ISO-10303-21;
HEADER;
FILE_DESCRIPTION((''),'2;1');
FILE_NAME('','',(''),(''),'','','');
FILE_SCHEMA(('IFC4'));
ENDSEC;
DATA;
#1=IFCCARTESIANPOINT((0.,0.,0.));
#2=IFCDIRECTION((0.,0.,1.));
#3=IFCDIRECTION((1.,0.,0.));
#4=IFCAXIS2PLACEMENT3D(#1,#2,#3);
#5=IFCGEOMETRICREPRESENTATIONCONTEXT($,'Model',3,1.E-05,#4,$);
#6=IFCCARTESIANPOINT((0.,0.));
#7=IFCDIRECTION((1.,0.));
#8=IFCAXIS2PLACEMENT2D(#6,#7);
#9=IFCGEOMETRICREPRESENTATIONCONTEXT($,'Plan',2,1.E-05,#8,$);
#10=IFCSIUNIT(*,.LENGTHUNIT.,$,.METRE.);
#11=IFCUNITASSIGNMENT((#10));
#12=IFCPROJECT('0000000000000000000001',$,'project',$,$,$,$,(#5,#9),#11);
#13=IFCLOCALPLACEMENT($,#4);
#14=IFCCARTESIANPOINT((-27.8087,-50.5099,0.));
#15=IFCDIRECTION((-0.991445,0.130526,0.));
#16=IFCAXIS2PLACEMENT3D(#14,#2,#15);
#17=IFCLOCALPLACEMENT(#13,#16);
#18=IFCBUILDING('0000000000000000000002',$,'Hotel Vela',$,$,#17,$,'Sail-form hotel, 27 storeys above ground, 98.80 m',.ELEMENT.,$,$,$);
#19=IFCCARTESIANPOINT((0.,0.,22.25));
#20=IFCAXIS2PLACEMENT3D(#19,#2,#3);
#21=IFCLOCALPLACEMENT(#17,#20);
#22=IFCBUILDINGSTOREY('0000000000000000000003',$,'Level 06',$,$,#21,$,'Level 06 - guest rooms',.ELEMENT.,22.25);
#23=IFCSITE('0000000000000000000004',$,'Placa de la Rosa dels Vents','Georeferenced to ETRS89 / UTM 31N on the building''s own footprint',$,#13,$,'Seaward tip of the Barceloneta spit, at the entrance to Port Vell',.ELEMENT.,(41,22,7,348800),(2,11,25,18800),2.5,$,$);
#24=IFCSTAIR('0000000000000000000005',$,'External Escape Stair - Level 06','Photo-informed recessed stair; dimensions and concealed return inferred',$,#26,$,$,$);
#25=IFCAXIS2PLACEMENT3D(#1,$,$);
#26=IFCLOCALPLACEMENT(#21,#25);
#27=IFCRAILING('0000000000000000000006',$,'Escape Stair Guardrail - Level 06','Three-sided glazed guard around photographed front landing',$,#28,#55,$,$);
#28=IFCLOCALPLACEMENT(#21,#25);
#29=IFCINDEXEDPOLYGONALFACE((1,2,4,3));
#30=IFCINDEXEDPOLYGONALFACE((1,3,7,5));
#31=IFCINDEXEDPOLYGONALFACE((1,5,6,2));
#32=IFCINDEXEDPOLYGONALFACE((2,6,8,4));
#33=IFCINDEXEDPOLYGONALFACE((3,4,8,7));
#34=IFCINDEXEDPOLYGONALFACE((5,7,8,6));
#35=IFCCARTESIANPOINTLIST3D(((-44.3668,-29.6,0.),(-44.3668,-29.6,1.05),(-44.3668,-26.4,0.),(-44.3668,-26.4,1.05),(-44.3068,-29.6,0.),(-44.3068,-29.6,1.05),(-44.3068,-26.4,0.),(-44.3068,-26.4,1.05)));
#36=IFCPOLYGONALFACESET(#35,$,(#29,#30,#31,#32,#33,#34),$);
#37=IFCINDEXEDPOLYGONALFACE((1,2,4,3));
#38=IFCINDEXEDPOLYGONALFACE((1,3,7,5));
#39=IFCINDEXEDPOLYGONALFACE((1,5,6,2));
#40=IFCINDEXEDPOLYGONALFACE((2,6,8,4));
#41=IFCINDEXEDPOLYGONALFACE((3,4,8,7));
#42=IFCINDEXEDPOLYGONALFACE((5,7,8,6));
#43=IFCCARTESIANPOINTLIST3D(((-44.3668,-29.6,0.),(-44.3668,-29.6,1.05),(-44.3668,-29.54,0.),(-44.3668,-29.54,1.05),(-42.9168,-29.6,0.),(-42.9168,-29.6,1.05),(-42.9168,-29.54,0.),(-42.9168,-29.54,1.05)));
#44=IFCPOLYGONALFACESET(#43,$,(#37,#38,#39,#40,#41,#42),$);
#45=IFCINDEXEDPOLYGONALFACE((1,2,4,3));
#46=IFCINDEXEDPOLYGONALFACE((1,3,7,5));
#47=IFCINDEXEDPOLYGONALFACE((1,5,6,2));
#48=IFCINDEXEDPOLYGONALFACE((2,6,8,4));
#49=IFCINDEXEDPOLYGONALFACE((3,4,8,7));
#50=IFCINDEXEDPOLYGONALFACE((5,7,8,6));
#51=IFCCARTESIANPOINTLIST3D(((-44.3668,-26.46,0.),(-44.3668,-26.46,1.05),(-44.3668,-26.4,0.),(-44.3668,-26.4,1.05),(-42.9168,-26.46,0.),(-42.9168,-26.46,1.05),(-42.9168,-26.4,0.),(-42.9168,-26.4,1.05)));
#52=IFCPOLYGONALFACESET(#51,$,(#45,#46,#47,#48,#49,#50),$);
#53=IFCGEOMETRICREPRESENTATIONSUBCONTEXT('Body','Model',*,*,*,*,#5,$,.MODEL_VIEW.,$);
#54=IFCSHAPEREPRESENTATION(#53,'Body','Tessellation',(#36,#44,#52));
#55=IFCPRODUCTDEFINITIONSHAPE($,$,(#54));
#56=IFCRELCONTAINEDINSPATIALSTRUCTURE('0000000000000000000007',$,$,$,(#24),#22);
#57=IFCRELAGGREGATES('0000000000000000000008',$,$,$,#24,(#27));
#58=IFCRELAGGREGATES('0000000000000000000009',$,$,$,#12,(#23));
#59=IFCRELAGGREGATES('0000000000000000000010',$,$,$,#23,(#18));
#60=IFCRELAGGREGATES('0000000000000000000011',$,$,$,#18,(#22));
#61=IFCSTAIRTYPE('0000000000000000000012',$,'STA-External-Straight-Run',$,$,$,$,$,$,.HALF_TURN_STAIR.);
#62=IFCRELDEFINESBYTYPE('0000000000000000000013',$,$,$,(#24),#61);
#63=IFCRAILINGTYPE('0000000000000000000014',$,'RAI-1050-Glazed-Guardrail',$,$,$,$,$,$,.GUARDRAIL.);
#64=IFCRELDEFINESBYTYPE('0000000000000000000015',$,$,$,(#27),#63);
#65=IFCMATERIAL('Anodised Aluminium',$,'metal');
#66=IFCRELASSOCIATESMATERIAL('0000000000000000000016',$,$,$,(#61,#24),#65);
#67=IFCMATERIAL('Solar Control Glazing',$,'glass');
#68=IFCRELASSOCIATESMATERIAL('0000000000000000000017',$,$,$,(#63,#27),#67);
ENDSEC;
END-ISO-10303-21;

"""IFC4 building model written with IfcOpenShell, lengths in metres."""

from ifc_helpers import new_model, si_unit, frame, origin_with_axes, origin_2d_with_axis, place, context, subcontext, project, spatial, line, indexed_curve, outline, extrude, material, type_object, element, aggregate, save


model = new_model("IFC4")

# Units and contexts
model_context = context("Model", 3, precision=1e-05, world=origin_with_axes())
plan_context = context("Plan", 2, precision=1e-05, world=origin_2d_with_axis())
body_context = subcontext(model_context, "Body", "Model", "MODEL_VIEW")
ifc_project = project(units=[si_unit("LENGTHUNIT", "METRE")], contexts=[model_context, plan_context])

# Site, building, storey
site_placement = place(None, origin_with_axes())
site = spatial("IfcSite", under=ifc_project, at=site_placement, Name="Placa de la Rosa dels Vents", Description="Georeferenced to ETRS89 / UTM 31N on the building's own footprint", LongName="Seaward tip of the Barceloneta spit, at the entrance to Port Vell", CompositionType="ELEMENT", RefLatitude=(41, 22, 7, 348800), RefLongitude=(2, 11, 25, 18800), RefElevation=2.5)
building_placement = place(site_placement, frame((-27.8087, -50.5099, 0.0), z_axis=(0.0, 0.0, 1.0), x_axis=(-0.991445, 0.130526, 0.0)))
building = spatial("IfcBuilding", under=site, at=building_placement, Name="Hotel Vela", LongName="Sail-form hotel, 27 storeys above ground, 98.80 m", CompositionType="ELEMENT")
storey_placement = place(building_placement, frame((0.0, 0.0, 22.25), z_axis=(0.0, 0.0, 1.0), x_axis=(1.0, 0.0, 0.0)))
storey = spatial("IfcBuildingStorey", under=building, at=storey_placement, Name="Level 06", LongName="Level 06 - guest rooms", CompositionType="ELEMENT", Elevation=22.25)

# Stair
ifc_material_1 = material(Name="Anodised Aluminium", Category="metal")
stair_type = type_object("IfcStairType", Name="STA-External-Straight-Run", PredefinedType="HALF_TURN_STAIR", material=ifc_material_1)
stair_placement = place(storey_placement, frame((0.0, 0.0, -22.25), z_axis=(0.0, 0.0, 1.0), x_axis=(1.0, 0.0, 0.0)))
stair = element("IfcStair", 1, at=stair_placement, inside=storey, type_object=stair_type, material=ifc_material_1, Name="External Escape Stair - Level 06", Description="Photo-informed recessed stair; dimensions and concealed return inferred")

# Shared definitions
ifc_material_2 = material(Name="Solar Control Glazing", Category="glass")

# Railing
railing_type = type_object("IfcRailingType", Name="RAI-1050-Glazed-Guardrail", PredefinedType="GUARDRAIL", material=ifc_material_2)
railing_placement = place(stair_placement, origin_with_axes())
railing = element("IfcRailing", 2, at=railing_placement, type_object=railing_type, material=ifc_material_2, Name="Escape Stair Guardrail - Level 06", Description="Three-sided glazed guard around photographed front landing", context=body_context, shape_type="SweptSolid", body=[
    extrude(outline(indexed_curve([(0.0, 0.0), (0.06, 0.0), (0.06, 3.2), (0.0, 3.2)], segments=[line(1, 2, 3, 4, 1)])), frame((-44.3668, -29.6, 22.25), z_axis=(0.0, 0.0, 1.0), x_axis=(1.0, 0.0, 0.0)), (0.0, 0.0, 1.0), 1.05),
    extrude(outline(indexed_curve([(0.0, 0.0), (1.45, 0.0), (1.45, 0.06), (0.0, 0.06)], segments=[line(1, 2, 3, 4, 1)])), frame((-44.3668, -29.6, 22.25), z_axis=(0.0, 0.0, 1.0), x_axis=(1.0, 0.0, 0.0)), (0.0, 0.0, 1.0), 1.05),
    extrude(outline(indexed_curve([(0.0, 0.0), (1.45, 0.0), (1.45, 0.06), (0.0, 0.06)], segments=[line(1, 2, 3, 4, 1)])), frame((-44.3668, -26.46, 22.25), z_axis=(0.0, 0.0, 1.0), x_axis=(1.0, 0.0, 0.0)), (0.0, 0.0, 1.0), 1.05),
])
aggregate(stair, [railing])

save(model, "model.ifc")
